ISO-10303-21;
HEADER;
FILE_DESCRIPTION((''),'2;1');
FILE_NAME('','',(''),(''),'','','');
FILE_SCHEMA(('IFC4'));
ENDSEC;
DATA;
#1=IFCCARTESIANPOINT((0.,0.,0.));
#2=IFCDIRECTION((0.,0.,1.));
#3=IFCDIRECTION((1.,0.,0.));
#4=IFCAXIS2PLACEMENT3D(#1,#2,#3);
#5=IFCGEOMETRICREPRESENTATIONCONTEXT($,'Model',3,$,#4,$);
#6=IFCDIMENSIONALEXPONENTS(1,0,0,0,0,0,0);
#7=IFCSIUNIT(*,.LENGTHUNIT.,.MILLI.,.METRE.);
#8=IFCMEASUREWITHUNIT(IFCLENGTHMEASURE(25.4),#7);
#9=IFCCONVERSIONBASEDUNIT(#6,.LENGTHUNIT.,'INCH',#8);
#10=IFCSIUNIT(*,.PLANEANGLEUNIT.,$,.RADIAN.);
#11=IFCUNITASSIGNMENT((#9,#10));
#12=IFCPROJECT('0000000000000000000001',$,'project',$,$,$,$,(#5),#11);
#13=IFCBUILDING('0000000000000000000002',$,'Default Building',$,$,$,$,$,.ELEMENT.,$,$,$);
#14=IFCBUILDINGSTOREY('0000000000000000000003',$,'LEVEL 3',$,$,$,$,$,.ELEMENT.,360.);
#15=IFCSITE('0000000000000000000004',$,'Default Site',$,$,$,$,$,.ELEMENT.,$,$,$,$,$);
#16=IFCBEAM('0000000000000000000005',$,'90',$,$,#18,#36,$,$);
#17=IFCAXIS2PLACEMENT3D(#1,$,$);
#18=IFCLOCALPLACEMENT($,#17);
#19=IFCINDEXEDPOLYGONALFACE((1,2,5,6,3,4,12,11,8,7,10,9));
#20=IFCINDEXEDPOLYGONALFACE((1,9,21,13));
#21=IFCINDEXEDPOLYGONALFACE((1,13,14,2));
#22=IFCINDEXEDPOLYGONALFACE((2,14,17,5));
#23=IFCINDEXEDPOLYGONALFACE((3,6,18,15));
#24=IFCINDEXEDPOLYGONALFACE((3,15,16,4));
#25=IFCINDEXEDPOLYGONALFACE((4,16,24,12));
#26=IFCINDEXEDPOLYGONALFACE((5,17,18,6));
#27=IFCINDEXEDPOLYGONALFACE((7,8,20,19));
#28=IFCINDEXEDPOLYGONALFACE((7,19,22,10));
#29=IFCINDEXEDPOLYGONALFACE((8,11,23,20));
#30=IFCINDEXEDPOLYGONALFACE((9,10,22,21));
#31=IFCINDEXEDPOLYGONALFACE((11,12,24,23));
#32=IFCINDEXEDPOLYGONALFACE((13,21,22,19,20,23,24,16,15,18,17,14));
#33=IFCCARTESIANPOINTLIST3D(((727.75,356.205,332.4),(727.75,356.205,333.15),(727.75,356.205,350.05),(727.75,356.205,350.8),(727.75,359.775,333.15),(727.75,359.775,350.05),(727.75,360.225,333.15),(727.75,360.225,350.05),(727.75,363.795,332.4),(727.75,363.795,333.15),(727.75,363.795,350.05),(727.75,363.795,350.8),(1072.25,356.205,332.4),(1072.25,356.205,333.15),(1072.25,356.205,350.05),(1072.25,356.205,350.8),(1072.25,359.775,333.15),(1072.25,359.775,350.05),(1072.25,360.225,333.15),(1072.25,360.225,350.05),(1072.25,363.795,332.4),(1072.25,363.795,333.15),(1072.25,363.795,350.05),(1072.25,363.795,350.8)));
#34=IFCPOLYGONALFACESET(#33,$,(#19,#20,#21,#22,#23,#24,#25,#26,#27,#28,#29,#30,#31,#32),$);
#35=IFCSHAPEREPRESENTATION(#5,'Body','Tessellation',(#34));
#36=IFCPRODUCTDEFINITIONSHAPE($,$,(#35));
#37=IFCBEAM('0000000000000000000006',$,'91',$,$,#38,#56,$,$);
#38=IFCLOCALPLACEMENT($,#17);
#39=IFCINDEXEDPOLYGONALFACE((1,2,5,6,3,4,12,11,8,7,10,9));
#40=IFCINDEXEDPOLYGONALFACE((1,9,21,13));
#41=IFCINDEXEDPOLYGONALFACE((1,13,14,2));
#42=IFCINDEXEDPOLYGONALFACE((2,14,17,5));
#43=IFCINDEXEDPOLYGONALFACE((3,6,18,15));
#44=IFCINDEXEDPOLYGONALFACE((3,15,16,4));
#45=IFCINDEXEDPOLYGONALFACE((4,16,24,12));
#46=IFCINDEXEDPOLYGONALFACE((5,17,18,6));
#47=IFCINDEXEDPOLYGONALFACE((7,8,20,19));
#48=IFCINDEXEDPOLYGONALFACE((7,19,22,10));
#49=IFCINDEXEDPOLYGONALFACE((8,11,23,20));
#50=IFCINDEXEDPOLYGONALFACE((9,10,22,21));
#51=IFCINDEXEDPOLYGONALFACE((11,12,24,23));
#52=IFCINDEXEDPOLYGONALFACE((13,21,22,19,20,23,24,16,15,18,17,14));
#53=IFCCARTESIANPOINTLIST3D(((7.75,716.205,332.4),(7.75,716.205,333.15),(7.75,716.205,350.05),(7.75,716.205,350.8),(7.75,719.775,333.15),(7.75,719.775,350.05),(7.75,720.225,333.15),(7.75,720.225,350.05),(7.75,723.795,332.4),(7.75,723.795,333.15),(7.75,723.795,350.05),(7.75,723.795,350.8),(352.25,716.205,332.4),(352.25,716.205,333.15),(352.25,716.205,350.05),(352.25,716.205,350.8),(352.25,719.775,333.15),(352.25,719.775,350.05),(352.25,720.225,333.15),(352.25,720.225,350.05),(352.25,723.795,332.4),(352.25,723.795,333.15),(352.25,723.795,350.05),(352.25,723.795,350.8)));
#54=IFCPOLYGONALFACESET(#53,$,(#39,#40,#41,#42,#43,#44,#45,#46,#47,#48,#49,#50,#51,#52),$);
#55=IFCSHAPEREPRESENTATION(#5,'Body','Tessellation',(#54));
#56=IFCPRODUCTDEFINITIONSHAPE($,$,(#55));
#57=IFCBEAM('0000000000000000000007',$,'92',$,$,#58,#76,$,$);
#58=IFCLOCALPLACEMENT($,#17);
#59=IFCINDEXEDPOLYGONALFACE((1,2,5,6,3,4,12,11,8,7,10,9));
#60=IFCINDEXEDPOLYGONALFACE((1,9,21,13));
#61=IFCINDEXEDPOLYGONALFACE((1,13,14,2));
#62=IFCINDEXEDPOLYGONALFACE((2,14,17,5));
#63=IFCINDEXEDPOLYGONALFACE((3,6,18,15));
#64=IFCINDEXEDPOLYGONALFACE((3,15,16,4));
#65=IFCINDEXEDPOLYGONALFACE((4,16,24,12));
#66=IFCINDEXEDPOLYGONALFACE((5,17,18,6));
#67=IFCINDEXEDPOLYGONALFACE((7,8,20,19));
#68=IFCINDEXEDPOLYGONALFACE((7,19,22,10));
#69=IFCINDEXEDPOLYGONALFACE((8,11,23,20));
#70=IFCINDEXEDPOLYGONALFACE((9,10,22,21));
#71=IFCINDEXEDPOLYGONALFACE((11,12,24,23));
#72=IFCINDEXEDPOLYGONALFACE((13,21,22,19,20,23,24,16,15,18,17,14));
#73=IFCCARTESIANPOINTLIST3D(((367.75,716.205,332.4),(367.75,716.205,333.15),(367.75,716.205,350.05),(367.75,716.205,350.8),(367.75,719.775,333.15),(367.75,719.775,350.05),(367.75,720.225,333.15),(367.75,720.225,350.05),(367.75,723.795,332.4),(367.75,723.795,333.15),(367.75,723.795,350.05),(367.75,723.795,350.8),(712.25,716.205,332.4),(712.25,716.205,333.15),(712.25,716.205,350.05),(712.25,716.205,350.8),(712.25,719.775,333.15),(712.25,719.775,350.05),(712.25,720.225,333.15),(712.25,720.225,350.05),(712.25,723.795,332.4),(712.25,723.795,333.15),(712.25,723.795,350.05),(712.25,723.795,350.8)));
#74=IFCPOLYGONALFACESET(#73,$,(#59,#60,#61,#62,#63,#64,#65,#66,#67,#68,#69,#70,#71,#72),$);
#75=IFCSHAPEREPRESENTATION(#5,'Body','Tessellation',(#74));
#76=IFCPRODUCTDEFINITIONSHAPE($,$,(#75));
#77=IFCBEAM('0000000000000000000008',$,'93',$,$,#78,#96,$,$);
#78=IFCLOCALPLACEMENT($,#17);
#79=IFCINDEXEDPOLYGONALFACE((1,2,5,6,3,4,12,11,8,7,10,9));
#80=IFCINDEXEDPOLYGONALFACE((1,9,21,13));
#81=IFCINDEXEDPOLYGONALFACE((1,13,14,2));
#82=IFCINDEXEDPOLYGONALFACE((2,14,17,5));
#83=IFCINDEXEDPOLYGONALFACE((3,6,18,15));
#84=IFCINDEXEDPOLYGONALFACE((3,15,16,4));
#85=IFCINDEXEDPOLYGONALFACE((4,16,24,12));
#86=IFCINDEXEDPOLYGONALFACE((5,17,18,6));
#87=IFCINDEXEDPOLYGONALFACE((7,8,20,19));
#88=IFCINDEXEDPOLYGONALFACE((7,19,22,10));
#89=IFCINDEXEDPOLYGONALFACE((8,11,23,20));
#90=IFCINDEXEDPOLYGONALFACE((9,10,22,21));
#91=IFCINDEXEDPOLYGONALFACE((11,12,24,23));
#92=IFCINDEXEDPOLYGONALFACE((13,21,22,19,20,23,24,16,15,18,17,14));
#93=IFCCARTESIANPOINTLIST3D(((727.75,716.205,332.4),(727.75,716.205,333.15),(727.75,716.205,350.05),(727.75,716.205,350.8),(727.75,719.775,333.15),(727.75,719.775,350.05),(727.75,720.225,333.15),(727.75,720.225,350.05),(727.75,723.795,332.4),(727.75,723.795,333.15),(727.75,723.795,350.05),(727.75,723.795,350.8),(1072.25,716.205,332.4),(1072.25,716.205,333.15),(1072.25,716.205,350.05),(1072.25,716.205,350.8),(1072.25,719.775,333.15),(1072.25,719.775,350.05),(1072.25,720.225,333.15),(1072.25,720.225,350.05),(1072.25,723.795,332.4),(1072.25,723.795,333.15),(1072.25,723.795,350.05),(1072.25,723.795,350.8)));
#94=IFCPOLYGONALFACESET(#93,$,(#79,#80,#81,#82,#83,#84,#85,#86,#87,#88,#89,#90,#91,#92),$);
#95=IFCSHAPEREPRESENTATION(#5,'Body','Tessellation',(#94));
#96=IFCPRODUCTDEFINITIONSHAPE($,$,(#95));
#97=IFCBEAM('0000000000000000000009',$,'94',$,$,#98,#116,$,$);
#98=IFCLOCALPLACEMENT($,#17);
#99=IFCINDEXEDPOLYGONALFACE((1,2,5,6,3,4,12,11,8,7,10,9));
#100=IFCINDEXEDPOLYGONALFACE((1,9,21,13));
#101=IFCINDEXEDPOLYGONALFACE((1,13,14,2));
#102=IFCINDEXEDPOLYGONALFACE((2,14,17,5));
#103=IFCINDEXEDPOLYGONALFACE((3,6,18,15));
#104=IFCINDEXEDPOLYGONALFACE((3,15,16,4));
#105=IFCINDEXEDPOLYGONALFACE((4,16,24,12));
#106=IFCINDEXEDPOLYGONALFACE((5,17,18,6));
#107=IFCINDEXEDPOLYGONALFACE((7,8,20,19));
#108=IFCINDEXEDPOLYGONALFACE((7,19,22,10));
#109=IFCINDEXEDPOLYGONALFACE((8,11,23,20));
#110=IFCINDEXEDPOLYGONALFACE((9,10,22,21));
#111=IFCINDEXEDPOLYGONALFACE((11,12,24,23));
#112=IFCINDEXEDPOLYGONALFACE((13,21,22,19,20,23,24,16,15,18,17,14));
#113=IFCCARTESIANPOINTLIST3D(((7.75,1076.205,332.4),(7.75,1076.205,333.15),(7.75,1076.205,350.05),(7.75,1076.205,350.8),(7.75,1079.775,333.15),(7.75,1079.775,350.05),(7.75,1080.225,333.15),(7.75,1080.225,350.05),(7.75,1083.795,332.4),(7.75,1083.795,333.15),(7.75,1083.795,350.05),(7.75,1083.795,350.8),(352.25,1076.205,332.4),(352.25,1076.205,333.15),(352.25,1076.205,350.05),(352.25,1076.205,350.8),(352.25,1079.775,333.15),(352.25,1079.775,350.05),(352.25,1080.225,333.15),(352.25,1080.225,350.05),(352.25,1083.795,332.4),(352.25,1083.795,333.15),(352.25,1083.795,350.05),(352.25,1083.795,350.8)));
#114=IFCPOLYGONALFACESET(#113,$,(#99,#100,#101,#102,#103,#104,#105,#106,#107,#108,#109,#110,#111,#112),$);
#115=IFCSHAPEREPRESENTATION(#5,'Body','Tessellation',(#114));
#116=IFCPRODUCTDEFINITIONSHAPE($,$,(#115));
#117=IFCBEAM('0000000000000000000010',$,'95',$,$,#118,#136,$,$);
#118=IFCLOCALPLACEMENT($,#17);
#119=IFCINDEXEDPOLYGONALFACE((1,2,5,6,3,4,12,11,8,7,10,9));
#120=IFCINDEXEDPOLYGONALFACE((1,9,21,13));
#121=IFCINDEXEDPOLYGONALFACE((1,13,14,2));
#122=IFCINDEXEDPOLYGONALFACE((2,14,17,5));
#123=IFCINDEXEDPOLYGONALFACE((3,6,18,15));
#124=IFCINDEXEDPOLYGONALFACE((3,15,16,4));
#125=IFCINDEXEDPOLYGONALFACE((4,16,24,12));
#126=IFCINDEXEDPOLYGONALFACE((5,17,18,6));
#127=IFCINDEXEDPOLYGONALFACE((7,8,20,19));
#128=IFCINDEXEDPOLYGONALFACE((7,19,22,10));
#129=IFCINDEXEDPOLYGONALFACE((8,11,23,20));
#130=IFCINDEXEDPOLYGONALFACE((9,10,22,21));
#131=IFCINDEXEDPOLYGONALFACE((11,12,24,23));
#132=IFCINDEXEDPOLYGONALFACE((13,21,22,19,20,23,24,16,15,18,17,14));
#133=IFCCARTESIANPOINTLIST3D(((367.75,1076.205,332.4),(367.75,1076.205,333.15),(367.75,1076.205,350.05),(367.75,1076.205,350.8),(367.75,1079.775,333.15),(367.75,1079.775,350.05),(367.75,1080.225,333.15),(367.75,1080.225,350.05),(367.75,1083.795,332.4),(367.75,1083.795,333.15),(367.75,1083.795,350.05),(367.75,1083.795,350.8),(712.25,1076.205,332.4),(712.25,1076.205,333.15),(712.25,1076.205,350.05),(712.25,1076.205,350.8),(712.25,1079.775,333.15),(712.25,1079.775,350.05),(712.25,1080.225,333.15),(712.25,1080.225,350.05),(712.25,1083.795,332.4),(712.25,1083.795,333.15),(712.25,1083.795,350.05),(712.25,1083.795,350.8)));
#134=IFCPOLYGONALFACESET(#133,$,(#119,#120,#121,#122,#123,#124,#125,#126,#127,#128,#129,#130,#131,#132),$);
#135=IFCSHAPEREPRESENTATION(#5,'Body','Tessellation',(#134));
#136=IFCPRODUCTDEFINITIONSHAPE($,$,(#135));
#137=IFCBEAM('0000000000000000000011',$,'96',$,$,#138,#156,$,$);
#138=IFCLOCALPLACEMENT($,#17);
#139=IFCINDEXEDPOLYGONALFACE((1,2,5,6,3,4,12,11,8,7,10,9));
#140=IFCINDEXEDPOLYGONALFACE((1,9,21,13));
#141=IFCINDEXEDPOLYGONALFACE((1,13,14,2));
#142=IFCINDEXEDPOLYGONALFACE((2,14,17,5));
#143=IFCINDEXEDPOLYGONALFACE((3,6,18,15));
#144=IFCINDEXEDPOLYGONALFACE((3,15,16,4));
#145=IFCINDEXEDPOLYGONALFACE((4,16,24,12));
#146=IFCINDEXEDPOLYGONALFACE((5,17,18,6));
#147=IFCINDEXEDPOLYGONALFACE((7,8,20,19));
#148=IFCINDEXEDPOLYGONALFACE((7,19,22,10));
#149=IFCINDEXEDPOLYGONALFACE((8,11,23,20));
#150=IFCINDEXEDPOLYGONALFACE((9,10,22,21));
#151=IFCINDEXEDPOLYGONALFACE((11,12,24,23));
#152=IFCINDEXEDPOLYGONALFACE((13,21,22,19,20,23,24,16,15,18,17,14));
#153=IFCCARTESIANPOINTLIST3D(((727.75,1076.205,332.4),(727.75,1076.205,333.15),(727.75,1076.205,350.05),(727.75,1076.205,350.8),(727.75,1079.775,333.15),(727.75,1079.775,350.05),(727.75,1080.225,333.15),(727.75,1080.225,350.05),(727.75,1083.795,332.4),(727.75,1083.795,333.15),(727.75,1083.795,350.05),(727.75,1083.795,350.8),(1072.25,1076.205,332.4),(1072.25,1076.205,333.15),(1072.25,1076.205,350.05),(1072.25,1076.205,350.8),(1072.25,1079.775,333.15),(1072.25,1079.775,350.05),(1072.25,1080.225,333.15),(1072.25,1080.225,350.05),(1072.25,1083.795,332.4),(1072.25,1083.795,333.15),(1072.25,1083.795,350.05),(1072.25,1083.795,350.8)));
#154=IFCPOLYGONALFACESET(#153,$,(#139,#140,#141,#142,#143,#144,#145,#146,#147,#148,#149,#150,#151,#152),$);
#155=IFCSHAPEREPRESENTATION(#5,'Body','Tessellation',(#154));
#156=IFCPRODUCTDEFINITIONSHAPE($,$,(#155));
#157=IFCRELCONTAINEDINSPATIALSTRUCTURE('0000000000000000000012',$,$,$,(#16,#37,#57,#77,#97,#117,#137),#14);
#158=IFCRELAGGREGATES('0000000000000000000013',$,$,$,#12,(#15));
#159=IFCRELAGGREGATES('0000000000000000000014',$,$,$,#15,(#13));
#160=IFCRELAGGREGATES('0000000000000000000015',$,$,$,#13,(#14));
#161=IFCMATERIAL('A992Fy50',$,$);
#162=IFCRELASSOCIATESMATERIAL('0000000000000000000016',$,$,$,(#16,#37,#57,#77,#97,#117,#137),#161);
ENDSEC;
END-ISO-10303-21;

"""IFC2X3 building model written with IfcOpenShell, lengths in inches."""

from ifc_helpers import new_model, entity, si_unit, converted_unit, frame, origin_with_axes, origin_2d_with_axis, place, context, project, spatial, i_section, transform_2d, derived_profile, extrude, material, element, save


model = new_model("IFC2X3")

# Units and contexts
model_context = context("Model", 3, world=origin_with_axes())
ifc_project = project(units=[converted_unit("LENGTHUNIT", "INCH", entity("IfcLengthMeasure", 25.4), si_unit("LENGTHUNIT", "METRE", prefix="MILLI"), dimensions=[1, 0, 0, 0, 0, 0, 0]), si_unit("PLANEANGLEUNIT", "RADIAN")], contexts=[model_context])

# Site, building, storey
site = spatial("IfcSite", under=ifc_project, Name="Default Site", CompositionType="ELEMENT")
building = spatial("IfcBuilding", under=site, Name="Default Building", CompositionType="ELEMENT")
storey = spatial("IfcBuildingStorey", under=building, Name="LEVEL 3", CompositionType="ELEMENT", Elevation=360.0)

# Shared definitions
ifc_material = material(Name="A992Fy50")

# Beams
for number, where, z_axis, x_axis, name in (
    (1, (727.75, 360.0, 360.0), (1.0, 0.0, 0.0), (0.0, 1.0, 0.0), "90"),
    (2, (7.75, 720.0, 360.0), (1.0, 0.0, 0.0), (0.0, 1.0, 0.0), "91"),
    (3, (367.75, 720.0, 360.0), (1.0, 0.0, 0.0), (0.0, 1.0, 0.0), "92"),
    (4, (727.75, 720.0, 360.0), (1.0, 0.0, 0.0), (0.0, 1.0, 0.0), "93"),
    (5, (7.75, 1080.0, 360.0), (1.0, 0.0, 0.0), (0.0, 1.0, 0.0), "94"),
    (6, (367.75, 1080.0, 360.0), (1.0, 0.0, 0.0), (0.0, 1.0, 0.0), "95"),
    (7, (727.75, 1080.0, 360.0), (1.0, 0.0, 0.0), (0.0, 1.0, 0.0), "96"),
):
    element("IfcBeam", number, at=place(None, frame(where, z_axis=z_axis, x_axis=x_axis)), inside=storey, material=ifc_material, Name=name, context=model_context, shape_type="SweptSolid", body=[
        extrude(derived_profile(i_section(OverallWidth=7.59, OverallDepth=18.4, WebThickness=0.45, FlangeThickness=0.75, at=origin_2d_with_axis()), transform_2d((0.0, -9.2))), origin_with_axes(), (0.0, 0.0, 1.0), 344.5),
    ])

save(model, "model.ifc")
